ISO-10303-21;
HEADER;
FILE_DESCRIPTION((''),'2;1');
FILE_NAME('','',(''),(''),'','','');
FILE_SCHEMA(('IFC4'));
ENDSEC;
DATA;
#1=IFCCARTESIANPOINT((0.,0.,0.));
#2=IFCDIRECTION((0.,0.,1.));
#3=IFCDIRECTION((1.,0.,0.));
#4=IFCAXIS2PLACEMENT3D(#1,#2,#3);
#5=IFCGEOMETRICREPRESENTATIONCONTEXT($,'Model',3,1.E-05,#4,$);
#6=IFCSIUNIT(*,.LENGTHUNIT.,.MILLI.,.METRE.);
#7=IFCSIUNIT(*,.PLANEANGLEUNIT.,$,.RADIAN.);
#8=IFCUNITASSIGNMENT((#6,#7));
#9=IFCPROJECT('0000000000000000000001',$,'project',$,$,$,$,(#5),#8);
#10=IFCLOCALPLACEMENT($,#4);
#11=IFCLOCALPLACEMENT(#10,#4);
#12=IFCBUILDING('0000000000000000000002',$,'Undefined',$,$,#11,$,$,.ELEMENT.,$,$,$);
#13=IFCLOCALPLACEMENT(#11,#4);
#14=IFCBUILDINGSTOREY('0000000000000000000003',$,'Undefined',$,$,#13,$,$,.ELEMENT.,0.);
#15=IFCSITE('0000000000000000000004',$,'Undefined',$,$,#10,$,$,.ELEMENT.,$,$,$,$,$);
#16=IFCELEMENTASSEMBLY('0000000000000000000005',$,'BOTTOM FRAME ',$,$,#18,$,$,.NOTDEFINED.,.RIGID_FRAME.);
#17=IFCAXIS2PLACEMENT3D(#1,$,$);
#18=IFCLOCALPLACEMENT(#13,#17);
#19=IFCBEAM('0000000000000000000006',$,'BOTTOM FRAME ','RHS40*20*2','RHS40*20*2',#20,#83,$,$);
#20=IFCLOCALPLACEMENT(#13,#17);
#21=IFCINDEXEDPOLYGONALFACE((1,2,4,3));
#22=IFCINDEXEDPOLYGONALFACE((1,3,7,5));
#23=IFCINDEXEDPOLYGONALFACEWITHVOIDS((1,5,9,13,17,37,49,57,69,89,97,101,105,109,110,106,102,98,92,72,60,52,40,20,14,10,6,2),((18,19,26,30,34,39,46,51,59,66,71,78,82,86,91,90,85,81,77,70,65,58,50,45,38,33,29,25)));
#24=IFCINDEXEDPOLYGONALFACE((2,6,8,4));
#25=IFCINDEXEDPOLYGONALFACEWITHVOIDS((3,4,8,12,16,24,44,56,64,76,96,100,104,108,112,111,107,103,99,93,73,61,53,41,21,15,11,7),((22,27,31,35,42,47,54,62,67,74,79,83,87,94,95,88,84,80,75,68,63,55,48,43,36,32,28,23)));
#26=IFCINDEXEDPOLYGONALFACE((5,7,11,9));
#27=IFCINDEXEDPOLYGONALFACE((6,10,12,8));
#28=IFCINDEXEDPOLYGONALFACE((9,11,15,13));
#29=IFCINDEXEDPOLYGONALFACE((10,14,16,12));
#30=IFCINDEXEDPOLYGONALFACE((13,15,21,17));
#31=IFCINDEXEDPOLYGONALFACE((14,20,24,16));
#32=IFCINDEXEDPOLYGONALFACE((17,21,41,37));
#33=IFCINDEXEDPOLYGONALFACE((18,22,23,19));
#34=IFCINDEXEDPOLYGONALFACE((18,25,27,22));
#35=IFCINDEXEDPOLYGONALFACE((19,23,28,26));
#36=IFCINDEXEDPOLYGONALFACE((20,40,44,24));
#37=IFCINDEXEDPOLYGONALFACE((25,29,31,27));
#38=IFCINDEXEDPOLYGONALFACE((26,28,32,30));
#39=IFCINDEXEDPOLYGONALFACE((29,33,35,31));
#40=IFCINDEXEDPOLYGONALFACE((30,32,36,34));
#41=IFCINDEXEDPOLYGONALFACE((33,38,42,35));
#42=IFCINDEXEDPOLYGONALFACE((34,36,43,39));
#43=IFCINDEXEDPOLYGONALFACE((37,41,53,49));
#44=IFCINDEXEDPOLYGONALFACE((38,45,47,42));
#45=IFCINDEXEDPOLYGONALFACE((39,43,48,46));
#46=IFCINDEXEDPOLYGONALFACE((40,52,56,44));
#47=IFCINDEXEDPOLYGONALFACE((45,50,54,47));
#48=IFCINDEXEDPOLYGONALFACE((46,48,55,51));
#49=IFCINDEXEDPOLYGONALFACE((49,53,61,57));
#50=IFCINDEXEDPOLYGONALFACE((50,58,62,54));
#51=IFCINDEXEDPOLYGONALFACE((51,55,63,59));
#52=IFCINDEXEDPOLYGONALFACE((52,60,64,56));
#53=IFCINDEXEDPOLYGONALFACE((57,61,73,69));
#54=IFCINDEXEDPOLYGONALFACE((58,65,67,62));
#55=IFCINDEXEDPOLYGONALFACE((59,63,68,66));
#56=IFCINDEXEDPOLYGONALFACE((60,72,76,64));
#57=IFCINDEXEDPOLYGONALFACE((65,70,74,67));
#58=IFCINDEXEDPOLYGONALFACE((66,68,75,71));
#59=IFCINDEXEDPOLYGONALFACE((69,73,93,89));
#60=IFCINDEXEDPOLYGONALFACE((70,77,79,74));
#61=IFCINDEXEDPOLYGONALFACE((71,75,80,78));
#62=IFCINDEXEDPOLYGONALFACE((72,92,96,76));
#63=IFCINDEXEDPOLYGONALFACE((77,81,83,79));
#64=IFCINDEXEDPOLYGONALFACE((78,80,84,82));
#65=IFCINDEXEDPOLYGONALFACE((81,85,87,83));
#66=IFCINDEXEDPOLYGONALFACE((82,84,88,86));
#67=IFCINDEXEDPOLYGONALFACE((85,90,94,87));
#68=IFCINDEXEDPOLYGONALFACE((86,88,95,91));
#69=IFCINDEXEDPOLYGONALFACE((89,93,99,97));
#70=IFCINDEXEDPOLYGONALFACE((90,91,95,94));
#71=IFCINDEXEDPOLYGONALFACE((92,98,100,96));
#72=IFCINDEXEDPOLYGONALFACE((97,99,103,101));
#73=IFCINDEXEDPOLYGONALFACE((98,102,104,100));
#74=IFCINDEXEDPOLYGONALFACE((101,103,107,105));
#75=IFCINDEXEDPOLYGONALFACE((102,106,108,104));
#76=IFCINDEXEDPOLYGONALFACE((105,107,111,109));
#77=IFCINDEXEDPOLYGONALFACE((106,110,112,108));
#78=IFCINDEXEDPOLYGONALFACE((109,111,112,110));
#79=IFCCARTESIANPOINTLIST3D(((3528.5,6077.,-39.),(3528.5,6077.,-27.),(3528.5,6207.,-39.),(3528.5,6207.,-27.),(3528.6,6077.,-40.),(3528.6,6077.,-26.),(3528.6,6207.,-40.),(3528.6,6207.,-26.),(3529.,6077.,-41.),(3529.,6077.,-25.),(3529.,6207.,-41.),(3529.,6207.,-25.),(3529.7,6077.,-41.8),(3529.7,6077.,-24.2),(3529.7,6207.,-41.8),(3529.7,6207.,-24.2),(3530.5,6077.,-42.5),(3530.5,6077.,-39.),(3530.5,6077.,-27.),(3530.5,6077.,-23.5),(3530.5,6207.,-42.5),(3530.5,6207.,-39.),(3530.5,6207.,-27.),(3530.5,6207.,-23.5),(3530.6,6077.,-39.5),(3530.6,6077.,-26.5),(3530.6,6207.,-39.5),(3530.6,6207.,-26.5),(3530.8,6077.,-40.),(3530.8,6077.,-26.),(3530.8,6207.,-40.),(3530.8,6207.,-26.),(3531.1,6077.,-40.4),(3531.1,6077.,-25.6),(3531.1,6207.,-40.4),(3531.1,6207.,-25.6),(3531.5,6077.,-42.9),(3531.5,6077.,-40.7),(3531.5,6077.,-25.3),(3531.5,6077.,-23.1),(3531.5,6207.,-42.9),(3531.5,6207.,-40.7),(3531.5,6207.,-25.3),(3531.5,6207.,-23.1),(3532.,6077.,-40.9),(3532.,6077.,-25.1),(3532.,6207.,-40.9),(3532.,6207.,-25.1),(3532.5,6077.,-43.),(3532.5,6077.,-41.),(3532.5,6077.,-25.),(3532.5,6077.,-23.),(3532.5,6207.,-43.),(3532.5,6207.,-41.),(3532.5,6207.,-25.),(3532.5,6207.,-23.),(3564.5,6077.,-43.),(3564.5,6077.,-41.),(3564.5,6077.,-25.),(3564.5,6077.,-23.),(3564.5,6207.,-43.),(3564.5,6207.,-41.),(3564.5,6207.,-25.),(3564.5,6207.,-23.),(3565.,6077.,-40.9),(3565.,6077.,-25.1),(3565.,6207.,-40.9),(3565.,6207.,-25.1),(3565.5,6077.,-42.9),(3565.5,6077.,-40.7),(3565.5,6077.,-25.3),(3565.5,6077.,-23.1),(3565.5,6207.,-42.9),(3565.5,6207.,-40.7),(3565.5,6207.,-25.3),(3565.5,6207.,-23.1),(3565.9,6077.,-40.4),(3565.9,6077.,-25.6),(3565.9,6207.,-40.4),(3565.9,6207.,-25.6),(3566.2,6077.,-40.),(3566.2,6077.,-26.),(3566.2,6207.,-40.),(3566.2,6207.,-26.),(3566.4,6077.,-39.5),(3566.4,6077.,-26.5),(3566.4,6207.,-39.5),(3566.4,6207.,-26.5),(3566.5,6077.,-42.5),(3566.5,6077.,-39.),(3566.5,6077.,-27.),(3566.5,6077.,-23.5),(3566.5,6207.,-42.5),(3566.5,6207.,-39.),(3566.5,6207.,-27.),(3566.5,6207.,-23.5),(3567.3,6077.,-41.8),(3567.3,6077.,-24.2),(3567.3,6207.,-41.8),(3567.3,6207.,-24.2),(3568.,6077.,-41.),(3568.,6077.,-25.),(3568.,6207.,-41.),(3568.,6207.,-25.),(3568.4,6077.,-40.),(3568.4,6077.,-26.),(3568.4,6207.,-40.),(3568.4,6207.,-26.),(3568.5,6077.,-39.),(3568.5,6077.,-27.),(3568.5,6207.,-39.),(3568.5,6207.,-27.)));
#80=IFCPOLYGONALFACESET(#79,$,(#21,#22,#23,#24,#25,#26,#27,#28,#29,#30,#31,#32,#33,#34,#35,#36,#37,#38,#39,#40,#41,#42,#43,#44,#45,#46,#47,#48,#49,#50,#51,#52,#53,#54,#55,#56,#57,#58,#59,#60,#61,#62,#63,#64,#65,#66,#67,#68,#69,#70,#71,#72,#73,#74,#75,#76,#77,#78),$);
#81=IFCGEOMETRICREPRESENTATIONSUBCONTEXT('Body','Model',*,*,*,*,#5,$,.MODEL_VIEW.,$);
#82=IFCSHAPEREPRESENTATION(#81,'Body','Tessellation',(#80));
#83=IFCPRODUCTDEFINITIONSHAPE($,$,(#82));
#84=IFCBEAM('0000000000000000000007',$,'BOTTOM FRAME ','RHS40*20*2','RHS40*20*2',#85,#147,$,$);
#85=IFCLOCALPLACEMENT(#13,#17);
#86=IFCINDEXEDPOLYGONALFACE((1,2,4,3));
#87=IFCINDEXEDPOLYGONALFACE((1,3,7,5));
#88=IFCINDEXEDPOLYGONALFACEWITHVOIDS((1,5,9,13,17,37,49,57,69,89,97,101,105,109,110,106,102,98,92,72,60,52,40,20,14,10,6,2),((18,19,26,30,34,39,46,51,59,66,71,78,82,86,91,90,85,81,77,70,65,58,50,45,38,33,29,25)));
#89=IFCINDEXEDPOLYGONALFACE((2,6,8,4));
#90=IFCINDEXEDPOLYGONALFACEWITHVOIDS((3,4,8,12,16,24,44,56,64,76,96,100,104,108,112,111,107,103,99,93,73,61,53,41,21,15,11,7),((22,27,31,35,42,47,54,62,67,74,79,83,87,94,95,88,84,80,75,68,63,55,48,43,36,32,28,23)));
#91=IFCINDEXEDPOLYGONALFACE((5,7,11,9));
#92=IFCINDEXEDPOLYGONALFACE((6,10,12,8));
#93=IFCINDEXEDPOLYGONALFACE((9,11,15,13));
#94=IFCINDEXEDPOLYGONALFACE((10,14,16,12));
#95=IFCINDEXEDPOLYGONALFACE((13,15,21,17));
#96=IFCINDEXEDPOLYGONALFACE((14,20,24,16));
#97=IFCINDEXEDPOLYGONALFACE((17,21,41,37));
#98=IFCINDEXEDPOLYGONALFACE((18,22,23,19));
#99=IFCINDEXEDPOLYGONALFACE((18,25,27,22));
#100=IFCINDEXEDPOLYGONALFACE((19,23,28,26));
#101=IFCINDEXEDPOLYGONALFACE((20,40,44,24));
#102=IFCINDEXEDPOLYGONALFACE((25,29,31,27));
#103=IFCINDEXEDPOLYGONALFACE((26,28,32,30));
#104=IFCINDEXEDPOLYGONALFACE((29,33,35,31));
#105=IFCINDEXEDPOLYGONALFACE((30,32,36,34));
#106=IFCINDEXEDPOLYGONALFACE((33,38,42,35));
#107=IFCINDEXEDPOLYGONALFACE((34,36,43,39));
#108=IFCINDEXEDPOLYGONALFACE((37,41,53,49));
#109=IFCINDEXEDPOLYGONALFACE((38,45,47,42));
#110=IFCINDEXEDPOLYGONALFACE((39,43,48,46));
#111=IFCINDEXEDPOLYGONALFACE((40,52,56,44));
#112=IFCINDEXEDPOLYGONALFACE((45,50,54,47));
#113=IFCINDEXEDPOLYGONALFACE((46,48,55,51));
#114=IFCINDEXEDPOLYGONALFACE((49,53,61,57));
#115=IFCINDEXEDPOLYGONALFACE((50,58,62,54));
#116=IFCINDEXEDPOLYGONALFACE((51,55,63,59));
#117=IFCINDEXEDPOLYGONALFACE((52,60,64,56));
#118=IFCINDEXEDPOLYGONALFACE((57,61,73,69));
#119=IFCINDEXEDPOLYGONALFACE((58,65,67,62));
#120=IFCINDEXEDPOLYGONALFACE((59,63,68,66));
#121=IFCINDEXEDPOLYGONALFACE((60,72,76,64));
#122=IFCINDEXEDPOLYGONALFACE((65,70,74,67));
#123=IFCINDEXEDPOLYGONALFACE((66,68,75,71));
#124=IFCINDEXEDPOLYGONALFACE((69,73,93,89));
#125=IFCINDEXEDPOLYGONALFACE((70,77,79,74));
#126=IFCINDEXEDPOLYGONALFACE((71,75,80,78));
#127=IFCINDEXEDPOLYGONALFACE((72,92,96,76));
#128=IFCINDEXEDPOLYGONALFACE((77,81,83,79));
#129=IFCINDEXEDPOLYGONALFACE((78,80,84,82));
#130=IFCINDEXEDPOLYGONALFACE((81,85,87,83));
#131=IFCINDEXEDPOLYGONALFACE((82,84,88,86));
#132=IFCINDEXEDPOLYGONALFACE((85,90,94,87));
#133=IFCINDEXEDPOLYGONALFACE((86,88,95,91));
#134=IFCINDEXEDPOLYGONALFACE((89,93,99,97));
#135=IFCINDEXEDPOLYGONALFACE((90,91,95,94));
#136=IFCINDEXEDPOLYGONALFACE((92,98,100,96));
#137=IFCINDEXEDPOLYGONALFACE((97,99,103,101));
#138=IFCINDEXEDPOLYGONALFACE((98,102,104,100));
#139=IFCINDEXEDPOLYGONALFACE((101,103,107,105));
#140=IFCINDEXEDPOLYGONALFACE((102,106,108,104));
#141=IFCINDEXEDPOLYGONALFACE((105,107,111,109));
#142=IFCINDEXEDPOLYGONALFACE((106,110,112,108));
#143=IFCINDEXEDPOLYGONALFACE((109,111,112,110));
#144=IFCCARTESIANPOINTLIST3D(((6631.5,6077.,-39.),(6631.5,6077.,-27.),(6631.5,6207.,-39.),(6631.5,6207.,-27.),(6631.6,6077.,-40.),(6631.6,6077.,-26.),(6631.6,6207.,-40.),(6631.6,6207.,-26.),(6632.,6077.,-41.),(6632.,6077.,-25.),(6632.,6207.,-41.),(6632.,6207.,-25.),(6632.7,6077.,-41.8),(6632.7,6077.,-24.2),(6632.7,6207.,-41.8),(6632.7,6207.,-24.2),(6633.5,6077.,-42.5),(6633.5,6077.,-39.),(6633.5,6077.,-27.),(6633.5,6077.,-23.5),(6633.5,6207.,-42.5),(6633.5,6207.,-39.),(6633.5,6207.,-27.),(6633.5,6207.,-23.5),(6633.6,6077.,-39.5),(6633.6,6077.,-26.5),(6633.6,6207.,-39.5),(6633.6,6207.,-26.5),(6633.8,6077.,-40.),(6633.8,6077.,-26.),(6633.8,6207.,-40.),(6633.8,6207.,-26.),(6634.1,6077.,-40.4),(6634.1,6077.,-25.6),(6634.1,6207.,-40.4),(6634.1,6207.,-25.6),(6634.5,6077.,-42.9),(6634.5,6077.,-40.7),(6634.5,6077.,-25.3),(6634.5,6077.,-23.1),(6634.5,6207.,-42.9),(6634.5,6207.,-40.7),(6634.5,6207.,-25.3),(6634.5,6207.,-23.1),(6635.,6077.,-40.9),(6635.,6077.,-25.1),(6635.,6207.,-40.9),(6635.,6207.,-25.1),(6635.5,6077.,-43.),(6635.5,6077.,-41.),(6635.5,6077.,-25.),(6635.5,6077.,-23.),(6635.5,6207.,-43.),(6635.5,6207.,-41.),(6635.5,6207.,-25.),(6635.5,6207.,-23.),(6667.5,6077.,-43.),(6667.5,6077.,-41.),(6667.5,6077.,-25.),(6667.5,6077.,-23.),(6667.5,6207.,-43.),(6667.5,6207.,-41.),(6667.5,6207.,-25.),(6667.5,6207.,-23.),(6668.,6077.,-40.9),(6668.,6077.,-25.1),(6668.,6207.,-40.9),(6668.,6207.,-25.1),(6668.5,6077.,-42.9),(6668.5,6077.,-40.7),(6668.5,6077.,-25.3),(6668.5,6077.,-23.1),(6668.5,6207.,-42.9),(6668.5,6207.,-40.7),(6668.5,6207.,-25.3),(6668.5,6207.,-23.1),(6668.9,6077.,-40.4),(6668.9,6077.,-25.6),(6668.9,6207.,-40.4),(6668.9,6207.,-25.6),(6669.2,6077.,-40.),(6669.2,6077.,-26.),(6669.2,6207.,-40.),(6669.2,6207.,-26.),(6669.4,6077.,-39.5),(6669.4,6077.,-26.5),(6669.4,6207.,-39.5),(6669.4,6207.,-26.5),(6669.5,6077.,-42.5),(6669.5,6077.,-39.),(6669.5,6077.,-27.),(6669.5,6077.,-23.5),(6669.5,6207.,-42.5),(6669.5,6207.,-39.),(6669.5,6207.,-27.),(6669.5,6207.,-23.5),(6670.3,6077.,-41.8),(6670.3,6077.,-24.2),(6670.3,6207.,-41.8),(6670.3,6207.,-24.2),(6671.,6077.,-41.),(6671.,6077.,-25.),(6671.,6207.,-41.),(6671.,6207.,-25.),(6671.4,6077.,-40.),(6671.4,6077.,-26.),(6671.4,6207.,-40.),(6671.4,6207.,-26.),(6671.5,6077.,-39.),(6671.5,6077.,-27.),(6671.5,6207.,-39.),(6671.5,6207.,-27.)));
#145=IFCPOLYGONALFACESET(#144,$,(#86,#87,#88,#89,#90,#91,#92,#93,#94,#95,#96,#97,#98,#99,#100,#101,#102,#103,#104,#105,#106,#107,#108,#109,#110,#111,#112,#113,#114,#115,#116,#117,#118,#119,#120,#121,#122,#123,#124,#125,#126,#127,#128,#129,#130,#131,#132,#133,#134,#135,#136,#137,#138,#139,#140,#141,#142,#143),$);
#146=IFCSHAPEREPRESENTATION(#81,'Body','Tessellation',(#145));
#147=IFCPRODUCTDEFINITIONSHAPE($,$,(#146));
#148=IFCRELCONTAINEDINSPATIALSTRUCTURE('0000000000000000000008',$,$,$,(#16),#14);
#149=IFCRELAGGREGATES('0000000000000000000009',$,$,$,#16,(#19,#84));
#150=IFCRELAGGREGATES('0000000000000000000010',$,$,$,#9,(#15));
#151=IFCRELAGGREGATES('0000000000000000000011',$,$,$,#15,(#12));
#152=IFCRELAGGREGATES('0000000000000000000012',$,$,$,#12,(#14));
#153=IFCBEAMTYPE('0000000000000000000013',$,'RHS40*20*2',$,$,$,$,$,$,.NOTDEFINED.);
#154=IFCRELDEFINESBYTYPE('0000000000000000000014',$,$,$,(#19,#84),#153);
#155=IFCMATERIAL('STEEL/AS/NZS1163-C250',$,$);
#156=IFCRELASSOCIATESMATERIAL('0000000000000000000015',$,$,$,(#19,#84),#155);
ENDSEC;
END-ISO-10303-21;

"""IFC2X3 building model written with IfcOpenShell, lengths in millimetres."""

from ifc_helpers import new_model, si_unit, frame, origin_with_axes, origin_2d_with_axis, place, context, subcontext, project, spatial, hollow_rectangle, extrude, material, type_object, element, aggregate, save


model = new_model("IFC2X3")

# Units and contexts
model_context = context("Model", 3, precision=1e-05, world=origin_with_axes())
body_context = subcontext(model_context, "Body", "Model", "MODEL_VIEW")
ifc_project = project(units=[si_unit("LENGTHUNIT", "METRE", prefix="MILLI"), si_unit("PLANEANGLEUNIT", "RADIAN")], contexts=[model_context])

# Site, building, storey
site_placement = place(None, origin_with_axes())
site = spatial("IfcSite", under=ifc_project, at=site_placement, Name="Undefined", CompositionType="ELEMENT")
building_placement = place(site_placement, origin_with_axes())
building = spatial("IfcBuilding", under=site, at=building_placement, Name="Undefined", CompositionType="ELEMENT")
storey_placement = place(building_placement, origin_with_axes())
storey = spatial("IfcBuildingStorey", under=building, at=storey_placement, Name="Undefined", CompositionType="ELEMENT", Elevation=0.0)

# Element assembly, beams
assembly_1_placement = place(storey_placement, origin_with_axes())
assembly_1 = element("IfcElementAssembly", 1, at=assembly_1_placement, inside=storey, Name="BOTTOM FRAME ", AssemblyPlace="NOTDEFINED", PredefinedType="RIGID_FRAME")
ifc_material_1 = material(Name="STEEL/AS/NZS1163-C250")
beam_type_1 = type_object("IfcBeamType", Name="RHS40*20*2", PredefinedType="NOTDEFINED")
beam_1_placement = place(assembly_1_placement, frame((3548.5, 6207.0, -33.0), z_axis=(1.0, 0.0, 0.0), x_axis=(0.0, -1.0, 0.0)))
beam_1 = element("IfcBeam", 2, at=beam_1_placement, type_object=beam_type_1, material=ifc_material_1, Name="BOTTOM FRAME ", Description="RHS40*20*2", ObjectType="RHS40*20*2", context=body_context, shape_type="SweptSolid", body=[
    extrude(hollow_rectangle(XDim=20.0, YDim=40.0, WallThickness=2.0, InnerFilletRadius=2.0, OuterFilletRadius=4.0, at=origin_2d_with_axis()), frame((130.0, 0.0, 0.0), z_axis=(-1.0, 0.0, 0.0), x_axis=(0.0, -1.0, 0.0)), (0.0, 0.0, 1.0), 130.0),
])
beam_2_placement = place(assembly_1_placement, frame((6651.5, 6207.0, -33.0), z_axis=(-1.0, 0.0, 0.0), x_axis=(0.0, -1.0, 0.0)))
beam_2 = element("IfcBeam", 3, at=beam_2_placement, type_object=beam_type_1, material=ifc_material_1, Name="BOTTOM FRAME ", Description="RHS40*20*2", ObjectType="RHS40*20*2", context=body_context, shape_type="SweptSolid", body=[
    extrude(hollow_rectangle(XDim=20.0, YDim=40.0, WallThickness=2.0, InnerFilletRadius=2.0, OuterFilletRadius=4.0, at=origin_2d_with_axis()), frame((130.0, 0.0, 0.0), z_axis=(-1.0, 0.0, 0.0), x_axis=(0.0, -1.0, 0.0)), (0.0, 0.0, 1.0), 130.0),
])

aggregate(assembly_1, [beam_1, beam_2])

save(model, "model.ifc")
